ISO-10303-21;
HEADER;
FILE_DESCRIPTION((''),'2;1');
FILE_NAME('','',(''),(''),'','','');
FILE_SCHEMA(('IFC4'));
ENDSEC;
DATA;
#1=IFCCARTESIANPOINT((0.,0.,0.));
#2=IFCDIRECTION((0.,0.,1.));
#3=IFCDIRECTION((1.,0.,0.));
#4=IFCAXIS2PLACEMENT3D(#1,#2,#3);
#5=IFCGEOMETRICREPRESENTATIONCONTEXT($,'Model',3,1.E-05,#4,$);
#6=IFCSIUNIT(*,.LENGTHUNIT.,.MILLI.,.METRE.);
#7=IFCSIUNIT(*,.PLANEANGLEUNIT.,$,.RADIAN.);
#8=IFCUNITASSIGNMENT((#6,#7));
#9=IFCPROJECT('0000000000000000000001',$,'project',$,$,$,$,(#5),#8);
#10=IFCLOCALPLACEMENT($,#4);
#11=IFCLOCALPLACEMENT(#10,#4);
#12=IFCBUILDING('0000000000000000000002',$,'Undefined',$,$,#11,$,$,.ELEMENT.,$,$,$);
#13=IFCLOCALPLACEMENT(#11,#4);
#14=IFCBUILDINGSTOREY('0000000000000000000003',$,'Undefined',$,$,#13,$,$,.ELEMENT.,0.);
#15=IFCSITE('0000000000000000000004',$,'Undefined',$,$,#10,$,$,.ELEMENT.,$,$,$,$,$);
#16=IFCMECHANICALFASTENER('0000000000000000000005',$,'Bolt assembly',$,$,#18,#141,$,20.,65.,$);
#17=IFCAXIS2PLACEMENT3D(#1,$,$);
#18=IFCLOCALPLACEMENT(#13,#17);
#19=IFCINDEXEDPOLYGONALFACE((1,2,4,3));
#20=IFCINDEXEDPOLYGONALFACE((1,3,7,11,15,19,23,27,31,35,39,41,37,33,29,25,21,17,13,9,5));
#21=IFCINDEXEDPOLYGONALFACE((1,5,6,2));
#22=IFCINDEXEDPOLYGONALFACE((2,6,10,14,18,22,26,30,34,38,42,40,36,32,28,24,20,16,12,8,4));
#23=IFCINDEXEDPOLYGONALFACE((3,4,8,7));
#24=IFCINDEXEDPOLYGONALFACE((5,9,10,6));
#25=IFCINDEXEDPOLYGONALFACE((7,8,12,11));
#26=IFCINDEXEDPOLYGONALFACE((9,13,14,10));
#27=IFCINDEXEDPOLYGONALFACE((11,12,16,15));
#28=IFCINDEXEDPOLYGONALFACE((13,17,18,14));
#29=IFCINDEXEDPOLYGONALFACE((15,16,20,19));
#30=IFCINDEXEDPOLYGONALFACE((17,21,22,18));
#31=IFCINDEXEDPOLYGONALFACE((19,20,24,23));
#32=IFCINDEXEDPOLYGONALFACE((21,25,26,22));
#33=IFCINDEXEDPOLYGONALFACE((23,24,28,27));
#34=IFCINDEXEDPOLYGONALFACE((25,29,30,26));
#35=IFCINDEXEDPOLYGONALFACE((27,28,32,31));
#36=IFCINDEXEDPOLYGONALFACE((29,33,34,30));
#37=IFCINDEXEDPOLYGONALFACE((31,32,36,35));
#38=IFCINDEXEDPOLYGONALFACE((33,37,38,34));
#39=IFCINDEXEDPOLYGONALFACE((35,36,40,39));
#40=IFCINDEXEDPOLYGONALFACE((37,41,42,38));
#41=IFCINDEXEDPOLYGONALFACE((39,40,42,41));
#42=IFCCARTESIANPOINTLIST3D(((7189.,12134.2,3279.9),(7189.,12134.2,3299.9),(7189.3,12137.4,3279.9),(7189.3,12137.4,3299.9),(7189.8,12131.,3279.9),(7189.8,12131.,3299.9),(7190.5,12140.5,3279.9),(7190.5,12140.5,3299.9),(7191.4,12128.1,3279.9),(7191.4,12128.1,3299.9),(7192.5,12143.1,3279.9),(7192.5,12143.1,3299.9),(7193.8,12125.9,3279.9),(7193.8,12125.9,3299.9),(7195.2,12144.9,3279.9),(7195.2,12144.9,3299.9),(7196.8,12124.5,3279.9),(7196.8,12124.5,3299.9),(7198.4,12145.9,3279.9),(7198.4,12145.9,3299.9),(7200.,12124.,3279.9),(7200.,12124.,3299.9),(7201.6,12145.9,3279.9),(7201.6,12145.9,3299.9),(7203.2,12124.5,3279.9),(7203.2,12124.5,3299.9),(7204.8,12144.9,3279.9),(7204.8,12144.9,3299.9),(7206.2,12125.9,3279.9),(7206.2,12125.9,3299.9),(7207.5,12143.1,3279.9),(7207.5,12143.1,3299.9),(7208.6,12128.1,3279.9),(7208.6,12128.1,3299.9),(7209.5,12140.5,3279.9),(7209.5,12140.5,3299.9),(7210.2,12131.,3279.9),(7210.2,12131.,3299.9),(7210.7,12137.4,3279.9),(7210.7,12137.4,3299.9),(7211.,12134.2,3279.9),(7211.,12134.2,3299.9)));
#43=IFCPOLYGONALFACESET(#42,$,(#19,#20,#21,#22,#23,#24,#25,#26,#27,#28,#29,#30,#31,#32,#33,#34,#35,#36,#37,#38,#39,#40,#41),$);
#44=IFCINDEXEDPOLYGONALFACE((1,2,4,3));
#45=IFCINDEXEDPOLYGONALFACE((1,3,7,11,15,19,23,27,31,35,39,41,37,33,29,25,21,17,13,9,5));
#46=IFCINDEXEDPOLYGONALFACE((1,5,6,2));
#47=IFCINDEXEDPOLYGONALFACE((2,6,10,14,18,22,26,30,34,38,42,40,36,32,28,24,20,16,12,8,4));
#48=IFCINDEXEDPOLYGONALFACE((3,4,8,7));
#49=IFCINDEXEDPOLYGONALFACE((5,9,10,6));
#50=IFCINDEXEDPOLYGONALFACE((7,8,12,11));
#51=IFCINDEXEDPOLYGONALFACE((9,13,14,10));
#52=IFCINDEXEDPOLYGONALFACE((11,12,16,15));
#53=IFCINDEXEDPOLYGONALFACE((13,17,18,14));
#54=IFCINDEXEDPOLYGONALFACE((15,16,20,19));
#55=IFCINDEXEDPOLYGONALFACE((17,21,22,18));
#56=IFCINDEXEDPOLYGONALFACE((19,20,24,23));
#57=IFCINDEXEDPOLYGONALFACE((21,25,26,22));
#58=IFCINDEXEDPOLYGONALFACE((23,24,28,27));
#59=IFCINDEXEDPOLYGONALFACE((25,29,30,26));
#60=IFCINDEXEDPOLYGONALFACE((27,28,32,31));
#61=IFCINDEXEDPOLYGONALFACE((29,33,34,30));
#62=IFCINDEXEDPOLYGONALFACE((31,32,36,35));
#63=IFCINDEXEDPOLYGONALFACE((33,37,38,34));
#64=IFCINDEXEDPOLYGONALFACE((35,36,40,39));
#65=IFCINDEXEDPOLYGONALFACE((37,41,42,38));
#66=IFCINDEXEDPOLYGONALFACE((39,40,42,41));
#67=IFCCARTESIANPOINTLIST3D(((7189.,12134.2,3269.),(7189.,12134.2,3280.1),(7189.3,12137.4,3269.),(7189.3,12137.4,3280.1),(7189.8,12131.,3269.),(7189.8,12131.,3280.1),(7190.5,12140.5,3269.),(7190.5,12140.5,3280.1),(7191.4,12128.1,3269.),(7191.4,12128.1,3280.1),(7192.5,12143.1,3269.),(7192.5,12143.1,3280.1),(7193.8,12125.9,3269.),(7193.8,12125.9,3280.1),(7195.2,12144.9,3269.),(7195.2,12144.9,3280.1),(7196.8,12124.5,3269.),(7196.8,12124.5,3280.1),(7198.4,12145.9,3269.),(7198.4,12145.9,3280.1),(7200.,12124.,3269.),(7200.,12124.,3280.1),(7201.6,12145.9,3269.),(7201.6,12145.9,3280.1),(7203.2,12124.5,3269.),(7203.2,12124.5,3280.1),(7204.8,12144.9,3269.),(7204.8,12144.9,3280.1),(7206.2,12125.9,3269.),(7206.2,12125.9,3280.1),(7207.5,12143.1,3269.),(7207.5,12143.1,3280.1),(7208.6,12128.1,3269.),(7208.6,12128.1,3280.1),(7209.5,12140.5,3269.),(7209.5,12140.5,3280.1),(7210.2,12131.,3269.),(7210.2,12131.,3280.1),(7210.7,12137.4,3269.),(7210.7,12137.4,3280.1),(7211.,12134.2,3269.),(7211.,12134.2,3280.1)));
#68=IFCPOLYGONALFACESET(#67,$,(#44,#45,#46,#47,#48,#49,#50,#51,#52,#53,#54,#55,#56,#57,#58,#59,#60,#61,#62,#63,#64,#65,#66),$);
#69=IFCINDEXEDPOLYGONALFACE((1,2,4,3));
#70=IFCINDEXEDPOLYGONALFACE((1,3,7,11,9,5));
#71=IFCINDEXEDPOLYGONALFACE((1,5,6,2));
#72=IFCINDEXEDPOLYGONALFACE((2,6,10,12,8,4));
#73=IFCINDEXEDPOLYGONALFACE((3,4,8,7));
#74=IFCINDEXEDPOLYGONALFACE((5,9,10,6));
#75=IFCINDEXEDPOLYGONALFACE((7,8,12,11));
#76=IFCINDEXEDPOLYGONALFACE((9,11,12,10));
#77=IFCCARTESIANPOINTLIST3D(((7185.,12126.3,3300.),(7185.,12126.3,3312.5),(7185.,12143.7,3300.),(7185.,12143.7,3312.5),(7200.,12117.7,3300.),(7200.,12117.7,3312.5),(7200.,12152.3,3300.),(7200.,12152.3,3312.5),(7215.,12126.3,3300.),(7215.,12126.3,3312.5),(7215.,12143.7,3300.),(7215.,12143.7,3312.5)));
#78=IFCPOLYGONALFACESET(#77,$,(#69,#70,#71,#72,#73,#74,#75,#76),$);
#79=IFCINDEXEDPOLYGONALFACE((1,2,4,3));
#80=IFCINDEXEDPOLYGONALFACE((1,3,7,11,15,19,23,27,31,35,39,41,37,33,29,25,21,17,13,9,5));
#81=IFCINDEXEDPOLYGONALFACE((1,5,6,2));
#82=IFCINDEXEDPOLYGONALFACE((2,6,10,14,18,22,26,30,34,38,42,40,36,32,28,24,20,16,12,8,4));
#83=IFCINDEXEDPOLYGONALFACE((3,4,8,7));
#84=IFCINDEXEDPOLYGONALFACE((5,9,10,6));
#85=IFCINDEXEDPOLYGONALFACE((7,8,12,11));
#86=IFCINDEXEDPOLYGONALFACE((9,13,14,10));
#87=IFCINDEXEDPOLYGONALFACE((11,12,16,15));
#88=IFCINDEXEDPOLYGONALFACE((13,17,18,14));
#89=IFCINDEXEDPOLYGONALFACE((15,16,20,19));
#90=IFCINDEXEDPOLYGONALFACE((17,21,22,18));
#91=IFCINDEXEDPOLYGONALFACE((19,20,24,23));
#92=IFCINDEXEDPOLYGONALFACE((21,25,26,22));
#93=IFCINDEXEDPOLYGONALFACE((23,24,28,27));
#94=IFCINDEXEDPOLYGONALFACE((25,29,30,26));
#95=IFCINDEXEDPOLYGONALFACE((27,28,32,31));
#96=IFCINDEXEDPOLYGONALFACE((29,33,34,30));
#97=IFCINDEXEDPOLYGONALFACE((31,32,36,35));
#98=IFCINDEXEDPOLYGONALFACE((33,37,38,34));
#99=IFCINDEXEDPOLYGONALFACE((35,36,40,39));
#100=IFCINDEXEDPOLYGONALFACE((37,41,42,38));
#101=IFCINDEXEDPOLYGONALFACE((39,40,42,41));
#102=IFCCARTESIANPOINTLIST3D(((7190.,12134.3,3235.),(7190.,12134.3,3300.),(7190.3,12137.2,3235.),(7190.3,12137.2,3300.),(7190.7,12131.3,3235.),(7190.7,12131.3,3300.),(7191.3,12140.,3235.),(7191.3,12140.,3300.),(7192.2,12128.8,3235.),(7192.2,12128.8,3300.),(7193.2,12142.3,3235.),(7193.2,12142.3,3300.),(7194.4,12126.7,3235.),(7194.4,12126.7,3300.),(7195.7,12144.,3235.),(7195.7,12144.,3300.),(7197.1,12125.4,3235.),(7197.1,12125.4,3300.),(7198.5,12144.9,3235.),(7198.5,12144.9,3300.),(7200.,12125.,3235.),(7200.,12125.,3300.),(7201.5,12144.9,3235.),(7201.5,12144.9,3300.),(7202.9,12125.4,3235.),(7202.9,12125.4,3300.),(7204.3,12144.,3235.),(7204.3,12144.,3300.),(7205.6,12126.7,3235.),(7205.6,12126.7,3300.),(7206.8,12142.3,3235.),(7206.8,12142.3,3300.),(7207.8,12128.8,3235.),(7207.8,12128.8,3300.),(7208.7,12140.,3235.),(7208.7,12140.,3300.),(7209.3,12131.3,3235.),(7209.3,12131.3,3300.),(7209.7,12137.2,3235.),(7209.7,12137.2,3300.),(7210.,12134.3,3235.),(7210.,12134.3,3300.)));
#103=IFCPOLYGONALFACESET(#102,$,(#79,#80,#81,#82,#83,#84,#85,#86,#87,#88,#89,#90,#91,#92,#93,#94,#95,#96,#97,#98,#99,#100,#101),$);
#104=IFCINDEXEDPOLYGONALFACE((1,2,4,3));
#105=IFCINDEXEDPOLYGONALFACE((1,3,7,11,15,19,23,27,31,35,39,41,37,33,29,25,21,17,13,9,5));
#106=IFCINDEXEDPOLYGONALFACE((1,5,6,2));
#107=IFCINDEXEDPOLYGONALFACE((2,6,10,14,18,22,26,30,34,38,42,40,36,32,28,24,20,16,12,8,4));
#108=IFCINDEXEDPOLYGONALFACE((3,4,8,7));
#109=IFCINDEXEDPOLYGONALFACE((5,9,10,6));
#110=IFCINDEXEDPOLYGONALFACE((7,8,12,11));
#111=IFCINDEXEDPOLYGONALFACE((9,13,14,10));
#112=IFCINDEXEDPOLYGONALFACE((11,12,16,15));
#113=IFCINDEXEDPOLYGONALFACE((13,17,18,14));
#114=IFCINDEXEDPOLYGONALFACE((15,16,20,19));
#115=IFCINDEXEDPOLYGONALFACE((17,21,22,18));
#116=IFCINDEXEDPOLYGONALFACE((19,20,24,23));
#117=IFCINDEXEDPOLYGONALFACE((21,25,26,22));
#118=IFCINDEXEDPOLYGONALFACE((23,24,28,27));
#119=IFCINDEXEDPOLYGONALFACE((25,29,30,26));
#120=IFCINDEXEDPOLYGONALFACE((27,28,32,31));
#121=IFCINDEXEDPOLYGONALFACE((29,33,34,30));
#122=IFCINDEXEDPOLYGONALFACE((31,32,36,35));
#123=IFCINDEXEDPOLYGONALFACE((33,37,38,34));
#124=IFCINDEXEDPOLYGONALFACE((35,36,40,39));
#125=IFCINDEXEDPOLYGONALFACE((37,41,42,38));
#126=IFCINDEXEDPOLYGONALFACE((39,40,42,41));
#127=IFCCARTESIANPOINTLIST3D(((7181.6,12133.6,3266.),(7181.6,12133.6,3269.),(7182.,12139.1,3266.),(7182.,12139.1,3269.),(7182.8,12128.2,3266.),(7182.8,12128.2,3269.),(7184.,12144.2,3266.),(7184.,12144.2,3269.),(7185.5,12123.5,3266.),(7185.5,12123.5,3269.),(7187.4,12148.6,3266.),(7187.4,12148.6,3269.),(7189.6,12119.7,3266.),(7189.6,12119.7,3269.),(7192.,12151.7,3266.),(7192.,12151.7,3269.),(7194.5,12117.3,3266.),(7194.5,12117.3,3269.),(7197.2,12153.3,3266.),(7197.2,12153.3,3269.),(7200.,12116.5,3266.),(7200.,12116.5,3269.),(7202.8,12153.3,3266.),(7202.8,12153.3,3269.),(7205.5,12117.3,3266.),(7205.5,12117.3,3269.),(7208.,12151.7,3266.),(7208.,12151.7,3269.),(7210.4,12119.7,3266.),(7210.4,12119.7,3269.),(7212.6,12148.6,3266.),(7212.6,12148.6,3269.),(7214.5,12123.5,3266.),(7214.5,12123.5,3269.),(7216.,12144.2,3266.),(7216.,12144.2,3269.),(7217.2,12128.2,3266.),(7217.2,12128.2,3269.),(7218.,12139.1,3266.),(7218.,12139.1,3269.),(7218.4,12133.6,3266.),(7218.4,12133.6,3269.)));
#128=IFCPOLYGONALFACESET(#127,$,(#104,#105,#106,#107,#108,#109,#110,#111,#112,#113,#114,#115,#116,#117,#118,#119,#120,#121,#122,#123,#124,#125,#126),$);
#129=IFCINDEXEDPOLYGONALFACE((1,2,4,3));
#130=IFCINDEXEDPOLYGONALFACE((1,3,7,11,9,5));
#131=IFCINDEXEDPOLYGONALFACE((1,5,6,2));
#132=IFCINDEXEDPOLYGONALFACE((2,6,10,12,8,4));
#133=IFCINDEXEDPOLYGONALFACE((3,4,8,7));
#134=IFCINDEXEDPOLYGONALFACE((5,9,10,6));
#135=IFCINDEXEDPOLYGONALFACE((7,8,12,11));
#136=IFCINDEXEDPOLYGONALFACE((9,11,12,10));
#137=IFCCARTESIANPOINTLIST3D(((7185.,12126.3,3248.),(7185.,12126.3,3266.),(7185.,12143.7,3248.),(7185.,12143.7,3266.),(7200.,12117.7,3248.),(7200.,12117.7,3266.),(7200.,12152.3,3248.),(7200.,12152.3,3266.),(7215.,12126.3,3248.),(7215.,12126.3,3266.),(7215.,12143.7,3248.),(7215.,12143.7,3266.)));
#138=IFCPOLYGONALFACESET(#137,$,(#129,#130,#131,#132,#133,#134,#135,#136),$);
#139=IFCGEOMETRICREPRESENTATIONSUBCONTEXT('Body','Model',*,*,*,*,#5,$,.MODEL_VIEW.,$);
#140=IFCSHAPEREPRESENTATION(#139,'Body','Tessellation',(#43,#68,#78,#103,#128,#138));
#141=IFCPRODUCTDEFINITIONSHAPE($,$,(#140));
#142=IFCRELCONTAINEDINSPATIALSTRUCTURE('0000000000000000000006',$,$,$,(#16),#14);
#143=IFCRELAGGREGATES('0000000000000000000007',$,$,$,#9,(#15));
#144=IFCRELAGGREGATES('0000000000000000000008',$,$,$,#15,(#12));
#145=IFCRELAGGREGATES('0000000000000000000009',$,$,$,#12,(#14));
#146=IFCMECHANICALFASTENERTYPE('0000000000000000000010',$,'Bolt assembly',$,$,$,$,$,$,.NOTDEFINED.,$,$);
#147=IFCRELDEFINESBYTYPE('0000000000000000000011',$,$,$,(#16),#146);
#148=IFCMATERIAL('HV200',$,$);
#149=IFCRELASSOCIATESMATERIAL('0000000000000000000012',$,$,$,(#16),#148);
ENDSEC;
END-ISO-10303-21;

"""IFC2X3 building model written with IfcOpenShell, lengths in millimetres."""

from ifc_helpers import new_model, si_unit, frame, origin_with_axes, origin_2d_with_axis, place, context, subcontext, project, spatial, polyline, circle, outline, extrude, source, transform, mapped, material, type_object, element, save


model = new_model("IFC2X3")

# Units and contexts
model_context = context("Model", 3, precision=1e-05, world=origin_with_axes())
body_context = subcontext(model_context, "Body", "Model", "MODEL_VIEW")
ifc_project = project(units=[si_unit("LENGTHUNIT", "METRE", prefix="MILLI"), si_unit("PLANEANGLEUNIT", "RADIAN")], contexts=[model_context])

# Site, building, storey
site_placement = place(None, origin_with_axes())
site = spatial("IfcSite", under=ifc_project, at=site_placement, Name="Undefined", CompositionType="ELEMENT")
building_placement = place(site_placement, origin_with_axes())
building = spatial("IfcBuilding", under=site, at=building_placement, Name="Undefined", CompositionType="ELEMENT")
storey_placement = place(building_placement, origin_with_axes())
storey = spatial("IfcBuildingStorey", under=building, at=storey_placement, Name="Undefined", CompositionType="ELEMENT", Elevation=0.0)

# Mechanical fastener
ifc_material_1 = material(Name="HV200")
mechanical_fastener_type = type_object("IfcMechanicalFastenerType", Name="Bolt assembly")
shared_shape_1 = source(origin_with_axes(), body_context, "Body", "SweptSolid", [
    extrude(circle(Radius=11.0, at=origin_2d_with_axis()), frame((0.0, -19.9, 0.0), z_axis=(0.0, 1.0, 0.0), x_axis=(1.0, 0.0, 0.0)), (0.0, 0.0, 1.0), 20.0),
    extrude(circle(Radius=11.0, at=origin_2d_with_axis()), frame((0.0, -0.1, 0.0), z_axis=(0.0, 1.0, 0.0), x_axis=(1.0, 0.0, 0.0)), (0.0, 0.0, 1.0), 11.1),
    extrude(outline(polyline([(17.3, 0.0), (8.7, 15.0), (-8.7, 15.0), (-17.3, 0.0), (-8.7, -15.0), (8.7, -15.0), (17.3, 0.0)])), frame((0.0, -32.5, 0.0), z_axis=(0.0, 1.0, 0.0), x_axis=(1.0, 0.0, 0.0)), (0.0, 0.0, 1.0), 12.5),
    extrude(circle(Radius=10.0, at=origin_2d_with_axis()), frame((0.0, -20.0, 0.0), z_axis=(0.0, 1.0, 0.0), x_axis=(1.0, 0.0, 0.0)), (0.0, 0.0, 1.0), 65.0),
    extrude(circle(Radius=18.5, at=origin_2d_with_axis()), frame((0.0, 11.0, 0.0), z_axis=(0.0, 1.0, 0.0), x_axis=(1.0, 0.0, 0.0)), (0.0, 0.0, 1.0), 3.0),
    extrude(outline(polyline([(17.3, 0.0), (8.7, 15.0), (-8.7, 15.0), (-17.3, 0.0), (-8.7, -15.0), (8.7, -15.0), (17.3, 0.0)])), frame((0.0, 14.0, 0.0), z_axis=(0.0, 1.0, 0.0), x_axis=(1.0, 0.0, 0.0)), (0.0, 0.0, 1.0), 18.0),
])
for number, where, z_axis, x_axis, name in (
    (1, (7200.0, 12135.0, 3280.0), (1.0, 0.0, 0.0), (0.0, -1.0, 0.0), "Bolt assembly"),
):
    element("IfcMechanicalFastener", number, at=place(storey_placement, frame(where, z_axis=z_axis, x_axis=x_axis)), inside=storey, type_object=mechanical_fastener_type, material=ifc_material_1, Name=name, NominalDiameter=20.0, NominalLength=65.0, context=body_context, shape_type="MappedRepresentation", body=[
        mapped(shared_shape_1, transform((0.0, 0.0, 0.0))),
    ])

save(model, "model.ifc")
